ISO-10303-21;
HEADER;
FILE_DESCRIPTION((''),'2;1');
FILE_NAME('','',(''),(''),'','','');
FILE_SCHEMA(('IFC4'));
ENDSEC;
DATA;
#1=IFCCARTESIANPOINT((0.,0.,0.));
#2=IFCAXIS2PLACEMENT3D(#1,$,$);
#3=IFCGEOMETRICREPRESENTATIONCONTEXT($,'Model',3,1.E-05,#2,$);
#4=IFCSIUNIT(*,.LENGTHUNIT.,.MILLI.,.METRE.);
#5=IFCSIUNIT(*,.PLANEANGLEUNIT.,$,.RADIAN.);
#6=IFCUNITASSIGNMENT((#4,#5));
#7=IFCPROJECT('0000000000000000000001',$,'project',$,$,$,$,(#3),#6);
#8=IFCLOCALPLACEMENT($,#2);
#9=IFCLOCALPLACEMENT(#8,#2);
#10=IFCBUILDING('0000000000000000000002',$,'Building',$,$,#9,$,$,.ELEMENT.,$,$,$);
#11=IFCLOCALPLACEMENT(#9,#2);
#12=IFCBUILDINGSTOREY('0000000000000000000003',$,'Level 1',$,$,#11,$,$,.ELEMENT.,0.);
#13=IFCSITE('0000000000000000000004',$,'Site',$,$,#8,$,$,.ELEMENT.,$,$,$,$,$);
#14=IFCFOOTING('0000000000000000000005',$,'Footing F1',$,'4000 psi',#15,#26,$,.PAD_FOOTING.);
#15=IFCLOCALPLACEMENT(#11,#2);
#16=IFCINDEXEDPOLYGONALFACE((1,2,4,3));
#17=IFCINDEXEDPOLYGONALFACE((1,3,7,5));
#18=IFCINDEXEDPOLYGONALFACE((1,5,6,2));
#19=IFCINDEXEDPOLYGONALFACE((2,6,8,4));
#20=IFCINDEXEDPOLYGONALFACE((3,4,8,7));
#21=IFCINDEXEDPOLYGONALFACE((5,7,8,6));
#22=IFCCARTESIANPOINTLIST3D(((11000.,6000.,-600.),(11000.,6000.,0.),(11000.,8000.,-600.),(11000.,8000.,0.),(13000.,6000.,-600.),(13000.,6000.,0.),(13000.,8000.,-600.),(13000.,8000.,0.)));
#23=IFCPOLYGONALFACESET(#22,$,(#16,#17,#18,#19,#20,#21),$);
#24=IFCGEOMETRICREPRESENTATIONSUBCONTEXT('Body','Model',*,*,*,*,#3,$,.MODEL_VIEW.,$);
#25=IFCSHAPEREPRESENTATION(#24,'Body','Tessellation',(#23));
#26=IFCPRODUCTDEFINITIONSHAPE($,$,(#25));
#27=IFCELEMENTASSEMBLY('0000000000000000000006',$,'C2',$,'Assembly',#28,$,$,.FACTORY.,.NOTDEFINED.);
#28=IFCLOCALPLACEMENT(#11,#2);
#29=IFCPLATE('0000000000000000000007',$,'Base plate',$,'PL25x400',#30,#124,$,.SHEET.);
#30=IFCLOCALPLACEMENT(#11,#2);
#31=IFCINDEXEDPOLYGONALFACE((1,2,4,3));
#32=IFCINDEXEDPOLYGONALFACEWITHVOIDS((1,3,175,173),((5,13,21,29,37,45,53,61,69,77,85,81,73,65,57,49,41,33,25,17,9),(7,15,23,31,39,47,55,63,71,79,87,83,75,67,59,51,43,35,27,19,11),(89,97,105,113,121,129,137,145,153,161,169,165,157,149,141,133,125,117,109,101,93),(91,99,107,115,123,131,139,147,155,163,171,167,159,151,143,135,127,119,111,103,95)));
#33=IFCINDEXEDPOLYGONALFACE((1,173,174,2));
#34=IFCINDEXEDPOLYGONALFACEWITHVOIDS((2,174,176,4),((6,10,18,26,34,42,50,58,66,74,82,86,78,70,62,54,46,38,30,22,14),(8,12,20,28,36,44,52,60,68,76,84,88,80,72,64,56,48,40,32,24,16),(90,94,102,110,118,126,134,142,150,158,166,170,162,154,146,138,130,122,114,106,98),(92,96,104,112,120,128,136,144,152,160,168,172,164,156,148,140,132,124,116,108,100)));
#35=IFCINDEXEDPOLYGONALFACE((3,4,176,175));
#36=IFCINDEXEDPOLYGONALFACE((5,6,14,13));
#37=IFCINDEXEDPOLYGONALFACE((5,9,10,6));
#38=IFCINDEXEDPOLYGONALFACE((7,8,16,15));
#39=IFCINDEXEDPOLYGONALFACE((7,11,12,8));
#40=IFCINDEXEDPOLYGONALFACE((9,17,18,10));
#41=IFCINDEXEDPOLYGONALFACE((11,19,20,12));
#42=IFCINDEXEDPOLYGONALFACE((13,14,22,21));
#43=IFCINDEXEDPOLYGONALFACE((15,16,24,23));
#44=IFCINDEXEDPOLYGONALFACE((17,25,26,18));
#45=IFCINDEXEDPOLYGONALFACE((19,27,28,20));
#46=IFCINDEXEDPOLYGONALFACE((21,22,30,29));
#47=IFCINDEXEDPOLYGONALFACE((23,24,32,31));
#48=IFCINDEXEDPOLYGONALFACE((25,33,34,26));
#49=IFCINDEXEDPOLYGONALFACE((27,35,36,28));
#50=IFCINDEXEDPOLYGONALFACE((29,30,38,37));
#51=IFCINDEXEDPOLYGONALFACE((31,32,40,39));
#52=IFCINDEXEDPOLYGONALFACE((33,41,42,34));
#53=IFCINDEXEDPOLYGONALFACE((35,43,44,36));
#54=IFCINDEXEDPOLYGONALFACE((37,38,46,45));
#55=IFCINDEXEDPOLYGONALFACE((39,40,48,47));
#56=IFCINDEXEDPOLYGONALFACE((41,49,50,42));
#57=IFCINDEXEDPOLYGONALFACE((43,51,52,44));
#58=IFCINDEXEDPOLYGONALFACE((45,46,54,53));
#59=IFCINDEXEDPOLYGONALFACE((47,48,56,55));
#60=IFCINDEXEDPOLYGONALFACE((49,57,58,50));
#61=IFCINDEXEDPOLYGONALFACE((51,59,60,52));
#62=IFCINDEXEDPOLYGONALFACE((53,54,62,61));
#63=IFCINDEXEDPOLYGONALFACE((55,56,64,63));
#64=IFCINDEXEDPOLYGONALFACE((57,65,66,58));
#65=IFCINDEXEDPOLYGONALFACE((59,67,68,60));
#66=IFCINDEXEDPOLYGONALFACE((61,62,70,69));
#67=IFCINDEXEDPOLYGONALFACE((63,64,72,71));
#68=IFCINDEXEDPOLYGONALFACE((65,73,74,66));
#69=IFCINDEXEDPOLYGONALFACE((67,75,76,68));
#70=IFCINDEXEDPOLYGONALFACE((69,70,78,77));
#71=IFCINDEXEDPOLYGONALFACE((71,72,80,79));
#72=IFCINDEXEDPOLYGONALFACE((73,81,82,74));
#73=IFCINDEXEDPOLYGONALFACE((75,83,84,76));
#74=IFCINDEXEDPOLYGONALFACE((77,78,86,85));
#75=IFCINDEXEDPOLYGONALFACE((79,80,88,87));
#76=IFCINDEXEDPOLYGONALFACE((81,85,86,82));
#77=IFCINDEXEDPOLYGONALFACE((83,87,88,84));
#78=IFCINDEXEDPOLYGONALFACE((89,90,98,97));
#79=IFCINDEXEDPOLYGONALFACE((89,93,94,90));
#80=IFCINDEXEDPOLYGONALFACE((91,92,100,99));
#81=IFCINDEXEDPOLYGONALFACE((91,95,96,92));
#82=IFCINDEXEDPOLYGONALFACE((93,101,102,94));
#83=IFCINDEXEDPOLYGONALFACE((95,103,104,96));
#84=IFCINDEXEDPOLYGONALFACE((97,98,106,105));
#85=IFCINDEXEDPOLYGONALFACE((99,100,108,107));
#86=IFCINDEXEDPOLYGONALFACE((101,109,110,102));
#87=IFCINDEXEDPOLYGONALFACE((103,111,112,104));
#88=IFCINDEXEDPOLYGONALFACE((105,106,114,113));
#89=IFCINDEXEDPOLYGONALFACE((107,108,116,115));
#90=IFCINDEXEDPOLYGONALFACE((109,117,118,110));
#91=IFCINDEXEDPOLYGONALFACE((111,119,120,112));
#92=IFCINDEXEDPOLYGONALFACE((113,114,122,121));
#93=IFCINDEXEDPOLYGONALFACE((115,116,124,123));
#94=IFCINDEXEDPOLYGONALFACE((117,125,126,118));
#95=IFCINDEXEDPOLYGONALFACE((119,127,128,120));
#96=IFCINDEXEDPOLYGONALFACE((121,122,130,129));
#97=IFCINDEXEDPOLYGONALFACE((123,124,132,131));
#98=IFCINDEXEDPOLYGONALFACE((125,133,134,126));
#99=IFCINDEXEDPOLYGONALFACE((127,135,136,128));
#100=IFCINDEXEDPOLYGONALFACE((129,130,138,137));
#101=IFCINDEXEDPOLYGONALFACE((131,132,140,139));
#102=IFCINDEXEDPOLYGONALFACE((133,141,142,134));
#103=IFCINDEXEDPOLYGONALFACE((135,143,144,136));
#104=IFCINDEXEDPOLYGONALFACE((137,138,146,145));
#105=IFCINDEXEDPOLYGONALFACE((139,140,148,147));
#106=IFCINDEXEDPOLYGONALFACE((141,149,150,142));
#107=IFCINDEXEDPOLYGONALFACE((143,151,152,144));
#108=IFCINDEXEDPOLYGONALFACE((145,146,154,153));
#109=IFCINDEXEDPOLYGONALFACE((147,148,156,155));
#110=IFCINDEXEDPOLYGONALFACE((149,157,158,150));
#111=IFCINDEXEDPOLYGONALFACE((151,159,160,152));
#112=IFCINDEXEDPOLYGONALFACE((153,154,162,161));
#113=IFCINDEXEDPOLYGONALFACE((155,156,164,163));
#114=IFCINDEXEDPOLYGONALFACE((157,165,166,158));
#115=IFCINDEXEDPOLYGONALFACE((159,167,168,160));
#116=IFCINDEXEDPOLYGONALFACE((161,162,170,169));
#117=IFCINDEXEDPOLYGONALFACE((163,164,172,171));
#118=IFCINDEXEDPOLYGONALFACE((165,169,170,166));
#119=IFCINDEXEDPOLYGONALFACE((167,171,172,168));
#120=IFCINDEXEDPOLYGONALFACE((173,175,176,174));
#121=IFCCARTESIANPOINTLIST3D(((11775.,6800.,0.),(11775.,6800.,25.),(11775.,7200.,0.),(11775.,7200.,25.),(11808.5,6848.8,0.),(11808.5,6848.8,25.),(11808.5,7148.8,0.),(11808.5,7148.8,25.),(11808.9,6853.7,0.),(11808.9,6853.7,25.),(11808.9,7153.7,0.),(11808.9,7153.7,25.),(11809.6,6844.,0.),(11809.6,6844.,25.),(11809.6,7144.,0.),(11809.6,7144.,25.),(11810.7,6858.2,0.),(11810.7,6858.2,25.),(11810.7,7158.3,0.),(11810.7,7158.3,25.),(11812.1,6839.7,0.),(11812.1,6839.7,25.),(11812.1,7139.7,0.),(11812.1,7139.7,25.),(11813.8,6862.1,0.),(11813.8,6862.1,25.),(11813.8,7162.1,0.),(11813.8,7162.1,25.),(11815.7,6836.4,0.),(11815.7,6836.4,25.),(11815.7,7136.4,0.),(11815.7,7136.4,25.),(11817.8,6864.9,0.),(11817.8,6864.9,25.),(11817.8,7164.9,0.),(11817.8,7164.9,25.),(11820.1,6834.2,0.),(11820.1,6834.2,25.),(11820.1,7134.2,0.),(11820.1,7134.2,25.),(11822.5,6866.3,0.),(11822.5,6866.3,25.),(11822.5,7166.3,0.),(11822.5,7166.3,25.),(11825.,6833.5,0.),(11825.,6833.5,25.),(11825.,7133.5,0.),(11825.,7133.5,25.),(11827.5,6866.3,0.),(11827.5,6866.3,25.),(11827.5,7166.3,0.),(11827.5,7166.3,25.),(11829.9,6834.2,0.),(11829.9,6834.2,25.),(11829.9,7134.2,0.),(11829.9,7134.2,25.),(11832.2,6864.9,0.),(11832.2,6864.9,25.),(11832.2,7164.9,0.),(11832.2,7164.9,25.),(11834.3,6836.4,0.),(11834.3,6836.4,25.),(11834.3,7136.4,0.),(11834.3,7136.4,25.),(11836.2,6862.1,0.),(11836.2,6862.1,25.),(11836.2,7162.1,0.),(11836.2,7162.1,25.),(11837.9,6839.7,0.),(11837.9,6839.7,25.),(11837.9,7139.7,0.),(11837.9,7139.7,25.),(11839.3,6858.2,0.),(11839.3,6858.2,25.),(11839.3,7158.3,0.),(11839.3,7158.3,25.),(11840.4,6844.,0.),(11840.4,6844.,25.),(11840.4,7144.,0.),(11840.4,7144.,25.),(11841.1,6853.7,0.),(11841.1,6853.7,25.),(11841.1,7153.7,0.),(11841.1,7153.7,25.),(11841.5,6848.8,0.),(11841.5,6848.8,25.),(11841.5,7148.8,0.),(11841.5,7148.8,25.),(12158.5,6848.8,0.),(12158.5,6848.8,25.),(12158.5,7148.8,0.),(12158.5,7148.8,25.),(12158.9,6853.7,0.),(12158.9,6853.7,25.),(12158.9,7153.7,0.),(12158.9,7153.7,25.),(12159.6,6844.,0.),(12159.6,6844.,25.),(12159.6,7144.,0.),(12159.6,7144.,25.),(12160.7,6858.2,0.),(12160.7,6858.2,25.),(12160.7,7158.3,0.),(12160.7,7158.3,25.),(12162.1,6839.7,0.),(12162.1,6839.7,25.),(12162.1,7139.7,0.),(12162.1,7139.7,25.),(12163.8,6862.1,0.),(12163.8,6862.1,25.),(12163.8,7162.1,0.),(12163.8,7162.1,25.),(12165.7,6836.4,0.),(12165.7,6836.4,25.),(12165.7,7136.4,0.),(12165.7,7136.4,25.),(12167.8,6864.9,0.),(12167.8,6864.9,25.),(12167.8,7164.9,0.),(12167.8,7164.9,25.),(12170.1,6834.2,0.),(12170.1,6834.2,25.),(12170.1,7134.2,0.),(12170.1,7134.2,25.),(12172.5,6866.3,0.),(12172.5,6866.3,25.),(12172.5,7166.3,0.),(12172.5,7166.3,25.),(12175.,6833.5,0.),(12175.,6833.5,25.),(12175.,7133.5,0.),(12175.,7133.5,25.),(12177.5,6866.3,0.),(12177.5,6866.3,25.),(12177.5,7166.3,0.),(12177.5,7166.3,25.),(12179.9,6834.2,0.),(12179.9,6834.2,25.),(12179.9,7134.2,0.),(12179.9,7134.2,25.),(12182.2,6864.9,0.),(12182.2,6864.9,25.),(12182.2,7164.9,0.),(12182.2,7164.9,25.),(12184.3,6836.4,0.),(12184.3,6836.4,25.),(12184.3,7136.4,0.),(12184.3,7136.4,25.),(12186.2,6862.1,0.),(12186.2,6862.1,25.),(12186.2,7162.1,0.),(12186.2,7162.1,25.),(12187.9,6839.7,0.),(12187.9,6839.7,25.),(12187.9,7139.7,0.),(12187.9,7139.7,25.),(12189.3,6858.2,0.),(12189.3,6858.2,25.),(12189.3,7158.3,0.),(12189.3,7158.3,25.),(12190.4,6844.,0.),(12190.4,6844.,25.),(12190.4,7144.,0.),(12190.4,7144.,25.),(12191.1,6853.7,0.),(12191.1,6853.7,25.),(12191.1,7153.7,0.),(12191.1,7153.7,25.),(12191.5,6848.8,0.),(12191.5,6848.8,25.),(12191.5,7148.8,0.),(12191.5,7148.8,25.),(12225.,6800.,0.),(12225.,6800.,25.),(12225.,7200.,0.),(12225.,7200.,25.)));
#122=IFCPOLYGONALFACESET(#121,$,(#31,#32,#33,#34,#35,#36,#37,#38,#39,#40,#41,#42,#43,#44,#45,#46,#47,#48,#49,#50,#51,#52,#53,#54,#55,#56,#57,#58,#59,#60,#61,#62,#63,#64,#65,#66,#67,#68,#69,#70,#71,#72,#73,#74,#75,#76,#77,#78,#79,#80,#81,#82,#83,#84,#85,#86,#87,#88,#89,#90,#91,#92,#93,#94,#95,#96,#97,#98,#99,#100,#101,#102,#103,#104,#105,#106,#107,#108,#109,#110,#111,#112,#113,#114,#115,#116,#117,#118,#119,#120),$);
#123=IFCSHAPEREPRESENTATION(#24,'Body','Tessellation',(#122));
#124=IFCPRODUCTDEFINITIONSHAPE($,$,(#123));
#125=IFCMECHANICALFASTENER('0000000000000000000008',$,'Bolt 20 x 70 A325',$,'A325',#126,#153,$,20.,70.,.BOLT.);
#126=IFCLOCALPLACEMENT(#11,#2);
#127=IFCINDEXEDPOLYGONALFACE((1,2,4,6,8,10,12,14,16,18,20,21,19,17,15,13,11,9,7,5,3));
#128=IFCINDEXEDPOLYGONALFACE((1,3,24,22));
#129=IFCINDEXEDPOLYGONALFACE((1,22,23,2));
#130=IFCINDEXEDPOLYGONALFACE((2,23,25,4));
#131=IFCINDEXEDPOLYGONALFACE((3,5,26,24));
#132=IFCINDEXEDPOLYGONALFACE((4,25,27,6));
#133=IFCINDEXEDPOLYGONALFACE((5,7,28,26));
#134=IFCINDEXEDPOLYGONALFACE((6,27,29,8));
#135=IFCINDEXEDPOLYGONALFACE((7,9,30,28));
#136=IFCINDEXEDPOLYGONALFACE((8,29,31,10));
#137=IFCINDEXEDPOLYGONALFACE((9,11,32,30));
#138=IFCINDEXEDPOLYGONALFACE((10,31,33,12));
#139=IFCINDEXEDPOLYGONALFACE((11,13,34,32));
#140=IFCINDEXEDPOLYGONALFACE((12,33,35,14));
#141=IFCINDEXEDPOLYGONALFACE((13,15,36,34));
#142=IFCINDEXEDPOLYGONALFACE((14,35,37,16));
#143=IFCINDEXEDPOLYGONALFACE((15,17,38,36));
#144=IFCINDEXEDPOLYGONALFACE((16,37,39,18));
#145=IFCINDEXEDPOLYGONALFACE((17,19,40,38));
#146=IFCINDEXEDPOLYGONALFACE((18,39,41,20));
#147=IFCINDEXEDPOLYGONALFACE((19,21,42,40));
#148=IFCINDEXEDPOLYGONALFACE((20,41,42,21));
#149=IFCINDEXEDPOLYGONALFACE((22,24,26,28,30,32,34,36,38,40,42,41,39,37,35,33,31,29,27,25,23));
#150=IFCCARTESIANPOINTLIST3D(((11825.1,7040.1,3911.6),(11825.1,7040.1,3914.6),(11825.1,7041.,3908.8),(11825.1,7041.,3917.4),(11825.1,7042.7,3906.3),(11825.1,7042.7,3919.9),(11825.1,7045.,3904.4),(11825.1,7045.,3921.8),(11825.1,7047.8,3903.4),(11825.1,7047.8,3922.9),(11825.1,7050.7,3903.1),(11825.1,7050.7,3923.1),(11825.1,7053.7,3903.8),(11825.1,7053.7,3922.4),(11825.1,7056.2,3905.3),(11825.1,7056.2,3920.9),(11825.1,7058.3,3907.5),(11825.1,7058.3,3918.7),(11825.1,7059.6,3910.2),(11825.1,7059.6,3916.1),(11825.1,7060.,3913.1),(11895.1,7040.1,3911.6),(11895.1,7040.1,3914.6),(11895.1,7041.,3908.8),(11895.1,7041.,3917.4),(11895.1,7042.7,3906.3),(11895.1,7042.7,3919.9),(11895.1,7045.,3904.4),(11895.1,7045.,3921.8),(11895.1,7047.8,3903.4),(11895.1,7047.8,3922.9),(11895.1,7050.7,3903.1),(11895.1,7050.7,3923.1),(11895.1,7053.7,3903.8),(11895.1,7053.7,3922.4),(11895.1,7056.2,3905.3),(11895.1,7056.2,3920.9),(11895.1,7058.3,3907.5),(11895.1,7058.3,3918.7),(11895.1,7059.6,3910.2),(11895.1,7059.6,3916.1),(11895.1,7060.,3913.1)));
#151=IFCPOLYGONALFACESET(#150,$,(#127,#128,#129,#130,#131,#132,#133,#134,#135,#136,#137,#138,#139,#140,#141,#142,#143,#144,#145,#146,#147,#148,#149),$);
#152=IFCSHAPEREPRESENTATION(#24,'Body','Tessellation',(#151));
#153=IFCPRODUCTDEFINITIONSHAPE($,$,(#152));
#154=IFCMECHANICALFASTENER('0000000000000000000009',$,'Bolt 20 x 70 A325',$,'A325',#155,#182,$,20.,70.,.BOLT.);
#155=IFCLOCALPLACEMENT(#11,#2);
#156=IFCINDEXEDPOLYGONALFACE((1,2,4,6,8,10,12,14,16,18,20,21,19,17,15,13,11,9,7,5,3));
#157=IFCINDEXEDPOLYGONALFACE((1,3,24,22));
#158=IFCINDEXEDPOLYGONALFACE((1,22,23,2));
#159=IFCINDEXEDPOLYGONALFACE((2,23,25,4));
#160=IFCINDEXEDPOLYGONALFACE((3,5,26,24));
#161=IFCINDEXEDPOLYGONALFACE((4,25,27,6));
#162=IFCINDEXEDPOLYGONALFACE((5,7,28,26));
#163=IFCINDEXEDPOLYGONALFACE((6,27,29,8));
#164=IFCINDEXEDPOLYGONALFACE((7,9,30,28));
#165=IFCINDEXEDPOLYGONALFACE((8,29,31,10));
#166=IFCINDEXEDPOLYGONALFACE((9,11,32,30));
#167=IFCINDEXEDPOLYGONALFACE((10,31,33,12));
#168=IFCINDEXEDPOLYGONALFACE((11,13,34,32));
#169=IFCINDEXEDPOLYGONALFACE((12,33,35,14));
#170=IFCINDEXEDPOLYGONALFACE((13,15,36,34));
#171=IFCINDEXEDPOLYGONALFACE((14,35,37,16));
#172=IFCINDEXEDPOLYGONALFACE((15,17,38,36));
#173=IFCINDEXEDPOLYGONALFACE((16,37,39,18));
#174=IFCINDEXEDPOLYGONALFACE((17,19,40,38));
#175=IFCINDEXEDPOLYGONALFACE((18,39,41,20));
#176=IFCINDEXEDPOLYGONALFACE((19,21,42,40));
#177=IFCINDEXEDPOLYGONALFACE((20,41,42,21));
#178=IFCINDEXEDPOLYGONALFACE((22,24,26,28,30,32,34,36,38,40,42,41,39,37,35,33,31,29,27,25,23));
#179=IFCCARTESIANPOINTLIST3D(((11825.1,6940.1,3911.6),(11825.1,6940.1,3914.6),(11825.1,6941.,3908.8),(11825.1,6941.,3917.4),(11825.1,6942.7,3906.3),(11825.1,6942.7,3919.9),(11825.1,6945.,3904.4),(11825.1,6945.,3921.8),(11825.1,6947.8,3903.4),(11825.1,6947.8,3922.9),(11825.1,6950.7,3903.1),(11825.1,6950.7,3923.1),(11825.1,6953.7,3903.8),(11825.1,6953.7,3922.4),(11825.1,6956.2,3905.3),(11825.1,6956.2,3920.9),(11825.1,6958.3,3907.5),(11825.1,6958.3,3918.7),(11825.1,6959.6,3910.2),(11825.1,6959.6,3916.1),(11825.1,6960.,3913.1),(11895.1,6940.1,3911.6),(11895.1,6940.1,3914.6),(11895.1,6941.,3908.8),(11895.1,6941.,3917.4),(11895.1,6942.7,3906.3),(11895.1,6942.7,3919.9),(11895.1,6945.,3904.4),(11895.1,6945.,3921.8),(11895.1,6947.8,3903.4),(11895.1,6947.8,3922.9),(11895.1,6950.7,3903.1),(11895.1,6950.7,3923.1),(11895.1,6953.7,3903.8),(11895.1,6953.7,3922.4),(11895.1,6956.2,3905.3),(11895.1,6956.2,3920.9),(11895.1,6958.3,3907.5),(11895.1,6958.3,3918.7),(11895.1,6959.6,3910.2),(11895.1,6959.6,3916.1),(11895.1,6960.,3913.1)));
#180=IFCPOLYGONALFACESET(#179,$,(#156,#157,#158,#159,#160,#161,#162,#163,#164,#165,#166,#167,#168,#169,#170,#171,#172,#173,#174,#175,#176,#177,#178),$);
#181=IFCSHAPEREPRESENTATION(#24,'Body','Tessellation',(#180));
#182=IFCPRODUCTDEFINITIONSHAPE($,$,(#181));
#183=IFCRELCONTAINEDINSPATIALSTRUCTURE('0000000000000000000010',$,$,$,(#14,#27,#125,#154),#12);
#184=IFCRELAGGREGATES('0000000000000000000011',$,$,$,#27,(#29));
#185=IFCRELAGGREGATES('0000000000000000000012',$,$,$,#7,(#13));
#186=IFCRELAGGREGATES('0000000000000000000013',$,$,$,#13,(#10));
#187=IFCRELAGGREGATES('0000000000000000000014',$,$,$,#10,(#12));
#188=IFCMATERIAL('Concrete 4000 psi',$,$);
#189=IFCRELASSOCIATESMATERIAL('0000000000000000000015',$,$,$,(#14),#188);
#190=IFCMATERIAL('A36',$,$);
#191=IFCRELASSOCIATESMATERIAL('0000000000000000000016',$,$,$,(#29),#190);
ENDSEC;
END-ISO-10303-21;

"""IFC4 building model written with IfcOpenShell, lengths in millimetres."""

from ifc_helpers import new_model, si_unit, frame, origin, origin_2d, place, context, subcontext, project, spatial, rectangle, circle, extrude, material, element, aggregate, save


model = new_model("IFC4")

# Units and contexts
model_context = context("Model", 3, precision=1e-05, world=origin())
body_context = subcontext(model_context, "Body", "Model", "MODEL_VIEW")
ifc_project = project(units=[si_unit("LENGTHUNIT", "METRE", prefix="MILLI"), si_unit("PLANEANGLEUNIT", "RADIAN")], contexts=[model_context])

# Site, building, storey
site_placement = place(None, origin())
site = spatial("IfcSite", under=ifc_project, at=site_placement, Name="Site", CompositionType="ELEMENT")
building_placement = place(site_placement, origin())
building = spatial("IfcBuilding", under=site, at=building_placement, Name="Building", CompositionType="ELEMENT")
storey_placement = place(building_placement, origin())
storey = spatial("IfcBuildingStorey", under=building, at=storey_placement, Name="Level 1", CompositionType="ELEMENT", Elevation=0.0)

# Footing
ifc_material_1 = material(Name="Concrete 4000 psi")
footing_placement = place(storey_placement, frame((12000.0, 7000.0, -600.0), z_axis=(0.0, 0.0, 1.0), x_axis=(1.0, 0.0, 0.0)))
element("IfcFooting", 1, at=footing_placement, inside=storey, material=ifc_material_1, Name="Footing F1", ObjectType="4000 psi", PredefinedType="PAD_FOOTING", context=body_context, shape_type="SweptSolid", body=[
    extrude(rectangle(XDim=2000.0, YDim=2000.0, at=origin_2d()), origin(), (0.0, 0.0, 1.0), 600.0),
])

# Element assembly, plate, openings
assembly_placement = place(storey_placement, origin())
assembly = element("IfcElementAssembly", 2, at=assembly_placement, inside=storey, Name="C2", ObjectType="Assembly", AssemblyPlace="FACTORY", PredefinedType="NOTDEFINED")
ifc_material_2 = material(Name="A36")
plate_placement = place(storey_placement, frame((11775.0, 7000.0, 12.5), z_axis=(1.0, 0.0, 0.0), x_axis=(0.0, 1.0, 0.0)))
plate = element("IfcPlate", 3, at=plate_placement, material=ifc_material_2, Name="Base plate", ObjectType="PL25x400", PredefinedType="SHEET", context=body_context, shape_type="SweptSolid", body=[
    extrude(rectangle(XDim=400.0, YDim=25.0, at=origin_2d()), origin(), (0.0, 0.0, 1.0), 450.0),
])
opening_1_placement = place(plate_placement, frame((-150.0, -13.5, 50.0), z_axis=(0.0, 1.0, 0.0), x_axis=(-1.0, 0.0, 0.0)))
element("IfcOpeningElement", 4, at=opening_1_placement, cuts=plate, PredefinedType="OPENING", context=body_context, shape_type="SweptSolid", body=[
    extrude(circle(Radius=16.5, at=origin_2d()), origin(), (0.0, 0.0, 1.0), 27.0),
])
opening_2_placement = place(plate_placement, frame((150.0, -13.5, 50.0), z_axis=(0.0, 1.0, 0.0), x_axis=(-1.0, 0.0, 0.0)))
element("IfcOpeningElement", 5, at=opening_2_placement, cuts=plate, PredefinedType="OPENING", context=body_context, shape_type="SweptSolid", body=[
    extrude(circle(Radius=16.5, at=origin_2d()), origin(), (0.0, 0.0, 1.0), 27.0),
])
opening_3_placement = place(plate_placement, frame((-150.0, -13.5, 400.0), z_axis=(0.0, 1.0, 0.0), x_axis=(-1.0, 0.0, 0.0)))
element("IfcOpeningElement", 6, at=opening_3_placement, cuts=plate, PredefinedType="OPENING", context=body_context, shape_type="SweptSolid", body=[
    extrude(circle(Radius=16.5, at=origin_2d()), origin(), (0.0, 0.0, 1.0), 27.0),
])
opening_4_placement = place(plate_placement, frame((150.0, -13.5, 400.0), z_axis=(0.0, 1.0, 0.0), x_axis=(-1.0, 0.0, 0.0)))
element("IfcOpeningElement", 7, at=opening_4_placement, cuts=plate, PredefinedType="OPENING", context=body_context, shape_type="SweptSolid", body=[
    extrude(circle(Radius=16.5, at=origin_2d()), origin(), (0.0, 0.0, 1.0), 27.0),
])
aggregate(assembly, [plate])

# Mechanical fasteners
for number, where, z_axis, x_axis, name in (
    (8, (11825.1, 7050.0, 3913.1), (1.0, 0.0, 0.0), (0.0, 1.0, 0.0), "Bolt 20 x 70 A325"),
    (9, (11825.1, 6950.0, 3913.1), (1.0, 0.0, 0.0), (0.0, 1.0, 0.0), "Bolt 20 x 70 A325"),
):
    element("IfcMechanicalFastener", number, at=place(storey_placement, frame(where, z_axis=z_axis, x_axis=x_axis)), inside=storey, Name=name, ObjectType="A325", NominalDiameter=20.0, NominalLength=70.0, PredefinedType="BOLT", context=body_context, shape_type="SweptSolid", body=[
        extrude(circle(Radius=10.0, at=origin_2d()), origin(), (0.0, 0.0, 1.0), 70.0),
    ])

save(model, "model.ifc")
